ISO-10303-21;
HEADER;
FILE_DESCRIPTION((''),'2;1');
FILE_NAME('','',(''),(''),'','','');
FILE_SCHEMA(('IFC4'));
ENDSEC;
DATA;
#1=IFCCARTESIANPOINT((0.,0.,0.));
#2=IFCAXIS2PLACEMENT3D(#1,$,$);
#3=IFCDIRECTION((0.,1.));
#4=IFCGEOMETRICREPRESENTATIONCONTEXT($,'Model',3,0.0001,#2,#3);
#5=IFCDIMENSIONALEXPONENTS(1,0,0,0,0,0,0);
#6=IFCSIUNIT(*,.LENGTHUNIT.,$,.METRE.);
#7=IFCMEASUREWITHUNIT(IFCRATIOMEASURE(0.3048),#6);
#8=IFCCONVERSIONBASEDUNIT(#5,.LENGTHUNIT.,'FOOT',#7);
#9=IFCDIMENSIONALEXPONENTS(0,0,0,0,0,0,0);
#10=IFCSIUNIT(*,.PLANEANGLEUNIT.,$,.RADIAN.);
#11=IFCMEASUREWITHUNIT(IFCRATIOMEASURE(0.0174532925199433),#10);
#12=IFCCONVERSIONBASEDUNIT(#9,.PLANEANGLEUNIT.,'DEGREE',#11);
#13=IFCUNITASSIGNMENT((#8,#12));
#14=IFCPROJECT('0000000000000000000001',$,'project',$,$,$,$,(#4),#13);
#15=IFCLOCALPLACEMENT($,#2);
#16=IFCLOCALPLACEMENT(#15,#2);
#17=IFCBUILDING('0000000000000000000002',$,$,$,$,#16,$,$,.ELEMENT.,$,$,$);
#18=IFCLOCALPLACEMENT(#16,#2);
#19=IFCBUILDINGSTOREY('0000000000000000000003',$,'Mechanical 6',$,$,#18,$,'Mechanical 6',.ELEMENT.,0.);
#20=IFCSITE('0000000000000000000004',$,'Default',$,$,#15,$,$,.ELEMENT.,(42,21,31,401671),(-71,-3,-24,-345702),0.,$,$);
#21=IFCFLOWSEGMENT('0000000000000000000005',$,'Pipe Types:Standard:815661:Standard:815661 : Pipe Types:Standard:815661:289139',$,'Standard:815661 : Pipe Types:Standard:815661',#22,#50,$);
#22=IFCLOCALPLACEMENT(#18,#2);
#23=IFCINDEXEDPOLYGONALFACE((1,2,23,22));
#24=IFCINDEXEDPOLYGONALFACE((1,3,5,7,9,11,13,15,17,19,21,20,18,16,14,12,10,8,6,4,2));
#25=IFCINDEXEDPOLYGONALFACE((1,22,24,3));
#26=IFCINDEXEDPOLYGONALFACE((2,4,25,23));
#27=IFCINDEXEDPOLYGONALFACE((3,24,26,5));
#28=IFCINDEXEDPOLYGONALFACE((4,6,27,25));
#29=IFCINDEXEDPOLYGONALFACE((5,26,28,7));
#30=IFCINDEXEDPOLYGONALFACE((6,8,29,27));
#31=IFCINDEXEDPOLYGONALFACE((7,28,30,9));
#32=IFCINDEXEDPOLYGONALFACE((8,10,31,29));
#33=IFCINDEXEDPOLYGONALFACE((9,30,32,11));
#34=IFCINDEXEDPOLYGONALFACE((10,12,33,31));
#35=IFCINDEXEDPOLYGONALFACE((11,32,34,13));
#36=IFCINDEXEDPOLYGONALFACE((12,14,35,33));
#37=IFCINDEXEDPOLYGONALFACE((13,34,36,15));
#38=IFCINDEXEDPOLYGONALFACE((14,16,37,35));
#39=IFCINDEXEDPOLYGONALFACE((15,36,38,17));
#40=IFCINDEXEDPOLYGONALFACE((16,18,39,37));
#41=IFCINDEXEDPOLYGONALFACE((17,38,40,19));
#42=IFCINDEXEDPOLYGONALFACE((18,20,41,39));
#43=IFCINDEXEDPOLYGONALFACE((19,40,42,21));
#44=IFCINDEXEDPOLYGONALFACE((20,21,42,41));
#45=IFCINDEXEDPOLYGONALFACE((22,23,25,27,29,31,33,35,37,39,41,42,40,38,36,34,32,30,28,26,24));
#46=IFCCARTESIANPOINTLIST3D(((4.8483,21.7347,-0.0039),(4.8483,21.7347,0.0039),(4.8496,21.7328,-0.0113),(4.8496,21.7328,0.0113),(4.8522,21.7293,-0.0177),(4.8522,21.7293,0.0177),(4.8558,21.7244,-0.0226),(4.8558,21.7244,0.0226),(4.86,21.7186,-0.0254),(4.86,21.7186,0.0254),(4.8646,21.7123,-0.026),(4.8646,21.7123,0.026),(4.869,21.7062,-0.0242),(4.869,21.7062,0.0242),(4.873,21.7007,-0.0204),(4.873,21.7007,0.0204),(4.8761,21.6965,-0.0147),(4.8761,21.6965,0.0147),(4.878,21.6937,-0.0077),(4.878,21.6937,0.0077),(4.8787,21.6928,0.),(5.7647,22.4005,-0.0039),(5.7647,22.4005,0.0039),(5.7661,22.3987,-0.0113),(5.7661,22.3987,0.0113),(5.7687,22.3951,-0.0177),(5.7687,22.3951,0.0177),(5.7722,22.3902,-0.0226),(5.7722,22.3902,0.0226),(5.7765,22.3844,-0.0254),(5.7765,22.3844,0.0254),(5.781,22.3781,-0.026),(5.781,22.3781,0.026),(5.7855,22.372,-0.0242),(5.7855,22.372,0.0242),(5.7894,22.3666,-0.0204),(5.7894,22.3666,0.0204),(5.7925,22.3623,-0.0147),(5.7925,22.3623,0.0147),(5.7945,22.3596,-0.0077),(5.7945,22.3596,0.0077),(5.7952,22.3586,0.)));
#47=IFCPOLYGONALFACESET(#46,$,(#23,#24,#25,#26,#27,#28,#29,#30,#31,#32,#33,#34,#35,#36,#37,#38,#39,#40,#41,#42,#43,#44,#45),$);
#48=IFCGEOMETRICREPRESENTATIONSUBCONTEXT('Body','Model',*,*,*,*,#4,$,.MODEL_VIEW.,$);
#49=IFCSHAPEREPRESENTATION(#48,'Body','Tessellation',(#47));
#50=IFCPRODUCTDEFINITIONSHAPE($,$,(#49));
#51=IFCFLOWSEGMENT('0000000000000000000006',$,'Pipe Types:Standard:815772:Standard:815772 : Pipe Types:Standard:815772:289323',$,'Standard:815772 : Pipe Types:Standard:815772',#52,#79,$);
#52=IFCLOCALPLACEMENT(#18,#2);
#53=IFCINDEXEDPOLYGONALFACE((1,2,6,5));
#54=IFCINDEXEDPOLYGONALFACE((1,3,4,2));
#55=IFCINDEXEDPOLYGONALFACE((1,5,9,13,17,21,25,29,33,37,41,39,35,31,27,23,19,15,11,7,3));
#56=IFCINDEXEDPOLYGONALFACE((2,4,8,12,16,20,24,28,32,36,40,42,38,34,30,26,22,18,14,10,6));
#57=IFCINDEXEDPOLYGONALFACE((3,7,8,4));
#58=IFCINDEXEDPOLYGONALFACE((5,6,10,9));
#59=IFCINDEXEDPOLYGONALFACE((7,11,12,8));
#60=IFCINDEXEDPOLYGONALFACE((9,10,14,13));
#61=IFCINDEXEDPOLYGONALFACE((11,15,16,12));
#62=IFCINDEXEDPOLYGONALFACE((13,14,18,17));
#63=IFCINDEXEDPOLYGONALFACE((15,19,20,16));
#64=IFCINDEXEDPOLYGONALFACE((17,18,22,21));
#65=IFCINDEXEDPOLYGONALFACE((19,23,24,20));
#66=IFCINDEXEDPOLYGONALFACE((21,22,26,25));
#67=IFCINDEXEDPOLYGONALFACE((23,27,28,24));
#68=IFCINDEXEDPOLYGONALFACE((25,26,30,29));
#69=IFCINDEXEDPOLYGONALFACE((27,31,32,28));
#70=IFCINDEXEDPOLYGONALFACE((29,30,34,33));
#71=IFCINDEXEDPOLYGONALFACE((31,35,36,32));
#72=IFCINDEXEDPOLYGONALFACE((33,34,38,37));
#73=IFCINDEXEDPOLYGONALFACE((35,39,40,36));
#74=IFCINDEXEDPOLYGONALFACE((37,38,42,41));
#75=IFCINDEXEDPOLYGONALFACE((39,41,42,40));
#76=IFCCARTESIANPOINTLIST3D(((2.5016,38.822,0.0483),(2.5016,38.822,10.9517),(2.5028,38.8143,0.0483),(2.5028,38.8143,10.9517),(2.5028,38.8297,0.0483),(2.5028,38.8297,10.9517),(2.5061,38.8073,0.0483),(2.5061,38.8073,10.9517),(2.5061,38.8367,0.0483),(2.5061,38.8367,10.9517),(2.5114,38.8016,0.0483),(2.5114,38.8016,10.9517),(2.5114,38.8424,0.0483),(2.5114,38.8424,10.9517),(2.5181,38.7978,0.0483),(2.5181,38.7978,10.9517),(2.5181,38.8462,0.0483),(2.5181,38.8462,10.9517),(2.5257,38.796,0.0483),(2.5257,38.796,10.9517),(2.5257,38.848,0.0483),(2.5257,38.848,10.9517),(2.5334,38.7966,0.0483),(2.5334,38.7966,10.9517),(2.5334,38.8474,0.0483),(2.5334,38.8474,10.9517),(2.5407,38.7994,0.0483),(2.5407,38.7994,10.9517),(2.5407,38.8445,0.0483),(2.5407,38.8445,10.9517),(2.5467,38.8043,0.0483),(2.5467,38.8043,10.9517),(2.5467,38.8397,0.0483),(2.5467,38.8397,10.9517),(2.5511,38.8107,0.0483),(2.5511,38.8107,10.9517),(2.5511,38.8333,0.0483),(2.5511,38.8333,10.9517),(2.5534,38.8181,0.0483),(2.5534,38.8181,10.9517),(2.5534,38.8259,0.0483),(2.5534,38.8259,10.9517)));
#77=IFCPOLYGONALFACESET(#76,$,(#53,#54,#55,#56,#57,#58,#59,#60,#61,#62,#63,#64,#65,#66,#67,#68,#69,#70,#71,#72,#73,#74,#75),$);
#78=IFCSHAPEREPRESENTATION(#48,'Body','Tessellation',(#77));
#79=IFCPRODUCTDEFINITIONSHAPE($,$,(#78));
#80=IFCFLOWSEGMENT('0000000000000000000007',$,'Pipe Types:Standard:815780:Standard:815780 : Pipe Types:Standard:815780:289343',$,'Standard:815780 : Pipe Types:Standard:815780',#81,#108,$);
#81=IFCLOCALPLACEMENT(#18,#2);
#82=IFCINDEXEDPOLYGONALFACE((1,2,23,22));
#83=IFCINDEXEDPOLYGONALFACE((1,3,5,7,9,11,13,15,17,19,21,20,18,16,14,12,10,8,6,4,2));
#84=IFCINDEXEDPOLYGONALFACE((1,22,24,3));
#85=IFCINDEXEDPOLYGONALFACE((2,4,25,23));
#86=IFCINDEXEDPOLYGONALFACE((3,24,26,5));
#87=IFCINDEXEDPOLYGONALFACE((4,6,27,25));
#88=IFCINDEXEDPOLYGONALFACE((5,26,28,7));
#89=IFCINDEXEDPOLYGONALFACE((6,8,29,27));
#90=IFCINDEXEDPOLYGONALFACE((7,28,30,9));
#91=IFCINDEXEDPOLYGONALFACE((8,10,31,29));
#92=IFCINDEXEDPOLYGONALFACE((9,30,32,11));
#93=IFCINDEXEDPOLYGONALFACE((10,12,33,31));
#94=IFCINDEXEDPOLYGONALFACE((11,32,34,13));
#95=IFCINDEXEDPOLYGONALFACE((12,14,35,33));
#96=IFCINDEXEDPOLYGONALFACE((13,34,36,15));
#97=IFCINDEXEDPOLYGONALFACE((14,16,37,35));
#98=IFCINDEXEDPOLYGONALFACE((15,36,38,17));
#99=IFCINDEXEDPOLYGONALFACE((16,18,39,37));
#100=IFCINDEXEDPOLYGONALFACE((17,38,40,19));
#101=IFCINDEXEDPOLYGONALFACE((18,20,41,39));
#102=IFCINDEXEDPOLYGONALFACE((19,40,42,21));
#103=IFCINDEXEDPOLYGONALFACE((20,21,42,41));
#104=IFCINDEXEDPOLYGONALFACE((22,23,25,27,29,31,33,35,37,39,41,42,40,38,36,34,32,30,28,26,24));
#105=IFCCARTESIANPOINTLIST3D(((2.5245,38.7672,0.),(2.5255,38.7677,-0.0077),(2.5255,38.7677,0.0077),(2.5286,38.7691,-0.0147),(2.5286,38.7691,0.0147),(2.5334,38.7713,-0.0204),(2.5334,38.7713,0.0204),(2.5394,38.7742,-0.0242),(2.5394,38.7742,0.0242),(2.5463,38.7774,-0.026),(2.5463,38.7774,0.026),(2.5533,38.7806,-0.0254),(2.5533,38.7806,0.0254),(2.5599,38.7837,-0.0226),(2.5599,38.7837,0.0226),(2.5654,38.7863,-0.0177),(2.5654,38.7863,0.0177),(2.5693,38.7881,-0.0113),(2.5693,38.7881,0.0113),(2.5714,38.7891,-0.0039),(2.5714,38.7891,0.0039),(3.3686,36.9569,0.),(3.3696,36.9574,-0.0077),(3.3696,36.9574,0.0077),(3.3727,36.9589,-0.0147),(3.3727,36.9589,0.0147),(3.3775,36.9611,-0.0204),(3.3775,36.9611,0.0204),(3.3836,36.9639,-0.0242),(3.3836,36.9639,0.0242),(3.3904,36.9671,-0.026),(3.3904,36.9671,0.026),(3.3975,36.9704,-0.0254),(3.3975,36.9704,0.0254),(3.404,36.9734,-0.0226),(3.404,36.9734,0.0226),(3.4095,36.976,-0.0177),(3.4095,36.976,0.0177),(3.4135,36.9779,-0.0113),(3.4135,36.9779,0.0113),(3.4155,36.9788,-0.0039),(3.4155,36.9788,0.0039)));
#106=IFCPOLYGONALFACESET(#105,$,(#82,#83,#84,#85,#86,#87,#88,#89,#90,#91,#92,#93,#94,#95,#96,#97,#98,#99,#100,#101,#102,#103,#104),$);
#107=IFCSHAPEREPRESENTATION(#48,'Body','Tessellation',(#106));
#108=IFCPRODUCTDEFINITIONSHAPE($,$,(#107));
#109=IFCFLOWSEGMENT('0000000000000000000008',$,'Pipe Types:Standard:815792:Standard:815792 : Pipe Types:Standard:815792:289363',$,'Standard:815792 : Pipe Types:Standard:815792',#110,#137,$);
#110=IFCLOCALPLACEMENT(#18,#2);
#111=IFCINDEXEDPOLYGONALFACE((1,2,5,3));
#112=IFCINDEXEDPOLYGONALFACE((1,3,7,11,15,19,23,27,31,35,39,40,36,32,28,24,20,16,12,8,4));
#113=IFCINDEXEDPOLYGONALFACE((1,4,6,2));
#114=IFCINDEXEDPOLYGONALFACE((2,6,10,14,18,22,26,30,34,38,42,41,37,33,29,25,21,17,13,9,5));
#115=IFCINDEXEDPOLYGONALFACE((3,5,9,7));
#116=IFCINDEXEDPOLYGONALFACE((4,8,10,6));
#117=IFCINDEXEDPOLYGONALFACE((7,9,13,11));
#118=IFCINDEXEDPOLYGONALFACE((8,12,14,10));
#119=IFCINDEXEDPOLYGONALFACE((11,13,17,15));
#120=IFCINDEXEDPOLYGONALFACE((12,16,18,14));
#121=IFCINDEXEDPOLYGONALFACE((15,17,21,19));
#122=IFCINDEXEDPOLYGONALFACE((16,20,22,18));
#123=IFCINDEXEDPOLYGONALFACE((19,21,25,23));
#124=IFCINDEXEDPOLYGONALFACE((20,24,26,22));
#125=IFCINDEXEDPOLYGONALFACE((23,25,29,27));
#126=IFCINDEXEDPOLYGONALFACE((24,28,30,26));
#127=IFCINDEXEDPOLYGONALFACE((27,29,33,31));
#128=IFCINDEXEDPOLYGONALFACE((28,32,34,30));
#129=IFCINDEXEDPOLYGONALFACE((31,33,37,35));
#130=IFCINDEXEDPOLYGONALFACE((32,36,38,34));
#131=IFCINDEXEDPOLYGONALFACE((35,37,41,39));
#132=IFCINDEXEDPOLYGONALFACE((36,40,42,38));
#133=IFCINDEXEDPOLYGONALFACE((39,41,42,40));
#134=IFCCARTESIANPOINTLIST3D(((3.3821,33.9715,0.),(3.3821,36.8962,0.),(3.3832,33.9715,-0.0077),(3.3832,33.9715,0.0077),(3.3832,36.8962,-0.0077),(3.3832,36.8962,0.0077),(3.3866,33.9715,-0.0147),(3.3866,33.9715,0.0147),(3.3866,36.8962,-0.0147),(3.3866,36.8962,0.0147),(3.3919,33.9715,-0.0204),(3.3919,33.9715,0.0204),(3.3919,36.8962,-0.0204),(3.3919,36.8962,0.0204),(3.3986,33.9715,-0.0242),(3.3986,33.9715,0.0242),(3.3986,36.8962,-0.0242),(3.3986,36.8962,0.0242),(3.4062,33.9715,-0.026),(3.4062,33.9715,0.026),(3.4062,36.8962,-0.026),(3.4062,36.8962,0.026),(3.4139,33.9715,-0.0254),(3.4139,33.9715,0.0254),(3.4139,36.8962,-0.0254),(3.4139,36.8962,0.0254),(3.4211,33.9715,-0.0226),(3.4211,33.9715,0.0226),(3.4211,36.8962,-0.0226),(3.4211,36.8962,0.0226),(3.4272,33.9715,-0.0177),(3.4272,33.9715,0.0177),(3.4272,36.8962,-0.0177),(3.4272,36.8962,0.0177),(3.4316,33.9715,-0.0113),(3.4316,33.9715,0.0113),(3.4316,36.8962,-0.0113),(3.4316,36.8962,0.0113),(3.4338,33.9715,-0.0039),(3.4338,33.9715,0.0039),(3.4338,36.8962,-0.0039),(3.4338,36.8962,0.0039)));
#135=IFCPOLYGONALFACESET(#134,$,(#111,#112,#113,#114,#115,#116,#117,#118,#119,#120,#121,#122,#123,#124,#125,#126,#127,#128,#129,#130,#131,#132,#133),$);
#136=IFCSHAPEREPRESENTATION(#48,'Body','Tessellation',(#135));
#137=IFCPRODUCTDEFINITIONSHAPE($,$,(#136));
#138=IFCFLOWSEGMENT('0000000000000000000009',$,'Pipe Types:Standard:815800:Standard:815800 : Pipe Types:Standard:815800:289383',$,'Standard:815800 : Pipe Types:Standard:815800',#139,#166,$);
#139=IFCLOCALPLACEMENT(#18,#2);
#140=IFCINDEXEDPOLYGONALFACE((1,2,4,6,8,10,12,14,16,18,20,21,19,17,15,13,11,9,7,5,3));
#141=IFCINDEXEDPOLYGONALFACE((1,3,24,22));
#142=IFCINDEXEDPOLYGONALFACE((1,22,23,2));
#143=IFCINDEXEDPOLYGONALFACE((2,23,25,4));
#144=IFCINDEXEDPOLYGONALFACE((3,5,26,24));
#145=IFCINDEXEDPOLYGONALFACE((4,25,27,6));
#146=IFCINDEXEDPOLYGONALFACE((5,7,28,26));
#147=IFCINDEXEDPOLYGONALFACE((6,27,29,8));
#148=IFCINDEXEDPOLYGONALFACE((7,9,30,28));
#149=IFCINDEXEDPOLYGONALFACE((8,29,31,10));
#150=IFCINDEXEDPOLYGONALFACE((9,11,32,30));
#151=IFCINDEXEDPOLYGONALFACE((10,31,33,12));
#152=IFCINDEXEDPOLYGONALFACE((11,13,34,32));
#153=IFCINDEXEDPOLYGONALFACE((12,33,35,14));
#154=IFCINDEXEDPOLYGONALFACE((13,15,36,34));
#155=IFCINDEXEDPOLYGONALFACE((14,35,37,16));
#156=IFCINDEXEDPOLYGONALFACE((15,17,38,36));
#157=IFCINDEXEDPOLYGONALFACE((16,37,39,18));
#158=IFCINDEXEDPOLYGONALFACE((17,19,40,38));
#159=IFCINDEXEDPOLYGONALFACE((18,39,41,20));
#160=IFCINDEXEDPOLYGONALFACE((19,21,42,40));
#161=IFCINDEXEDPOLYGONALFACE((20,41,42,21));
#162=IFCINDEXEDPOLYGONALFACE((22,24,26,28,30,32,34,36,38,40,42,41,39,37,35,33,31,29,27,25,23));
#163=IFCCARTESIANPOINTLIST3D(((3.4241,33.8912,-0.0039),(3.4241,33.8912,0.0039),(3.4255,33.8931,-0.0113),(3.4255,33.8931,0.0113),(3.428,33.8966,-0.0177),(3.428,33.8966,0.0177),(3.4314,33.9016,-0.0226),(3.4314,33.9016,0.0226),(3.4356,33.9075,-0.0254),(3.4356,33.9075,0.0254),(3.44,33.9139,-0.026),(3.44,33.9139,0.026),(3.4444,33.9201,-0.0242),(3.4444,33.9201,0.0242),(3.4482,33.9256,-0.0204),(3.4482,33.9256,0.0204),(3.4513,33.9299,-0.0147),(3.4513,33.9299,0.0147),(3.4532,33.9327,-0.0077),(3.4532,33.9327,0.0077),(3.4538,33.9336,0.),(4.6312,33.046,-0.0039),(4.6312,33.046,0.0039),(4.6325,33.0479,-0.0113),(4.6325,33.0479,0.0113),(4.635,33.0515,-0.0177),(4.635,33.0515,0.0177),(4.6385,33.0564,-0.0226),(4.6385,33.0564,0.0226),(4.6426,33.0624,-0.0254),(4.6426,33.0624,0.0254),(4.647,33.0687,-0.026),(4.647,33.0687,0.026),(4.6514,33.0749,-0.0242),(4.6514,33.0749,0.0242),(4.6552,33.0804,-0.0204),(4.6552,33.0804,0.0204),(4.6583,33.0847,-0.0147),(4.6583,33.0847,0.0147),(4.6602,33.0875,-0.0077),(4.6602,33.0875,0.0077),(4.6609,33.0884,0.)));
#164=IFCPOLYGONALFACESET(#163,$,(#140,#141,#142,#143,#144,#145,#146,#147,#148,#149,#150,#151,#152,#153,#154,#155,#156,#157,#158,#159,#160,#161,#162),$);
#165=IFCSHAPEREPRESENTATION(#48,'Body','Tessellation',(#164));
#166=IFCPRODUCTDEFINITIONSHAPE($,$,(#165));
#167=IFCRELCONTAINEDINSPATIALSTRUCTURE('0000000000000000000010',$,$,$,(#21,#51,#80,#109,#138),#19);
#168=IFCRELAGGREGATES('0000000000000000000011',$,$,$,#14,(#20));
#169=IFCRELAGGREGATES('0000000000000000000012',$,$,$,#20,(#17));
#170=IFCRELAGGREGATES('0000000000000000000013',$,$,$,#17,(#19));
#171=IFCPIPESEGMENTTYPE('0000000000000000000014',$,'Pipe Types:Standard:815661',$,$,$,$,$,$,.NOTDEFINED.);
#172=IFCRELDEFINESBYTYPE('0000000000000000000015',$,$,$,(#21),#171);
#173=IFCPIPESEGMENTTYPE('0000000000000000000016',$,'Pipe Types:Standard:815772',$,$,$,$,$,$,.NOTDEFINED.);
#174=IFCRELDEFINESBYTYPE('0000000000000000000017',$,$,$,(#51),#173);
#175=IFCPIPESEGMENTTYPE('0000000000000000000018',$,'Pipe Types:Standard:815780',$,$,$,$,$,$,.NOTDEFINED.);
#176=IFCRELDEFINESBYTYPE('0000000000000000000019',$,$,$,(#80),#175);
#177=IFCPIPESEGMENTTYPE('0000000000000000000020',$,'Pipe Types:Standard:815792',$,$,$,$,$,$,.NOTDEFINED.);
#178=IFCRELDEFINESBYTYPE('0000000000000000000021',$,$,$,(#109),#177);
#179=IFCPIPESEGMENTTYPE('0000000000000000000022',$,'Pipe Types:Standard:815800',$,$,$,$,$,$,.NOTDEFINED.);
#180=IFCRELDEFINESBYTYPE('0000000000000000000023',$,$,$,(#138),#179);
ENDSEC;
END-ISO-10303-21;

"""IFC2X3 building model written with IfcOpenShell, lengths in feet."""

from ifc_helpers import new_model, entity, si_unit, converted_unit, direction, frame, frame_2d, origin, origin_2d_with_axis, place, context, subcontext, project, spatial, circle, extrude, source, transform, mapped, type_object, type_shapes, element, save


model = new_model("IFC2X3")

# Units and contexts
model_context = context("Model", 3, precision=0.0001, world=origin(), true_north=direction((0.0, 1.0)))
body_context = subcontext(model_context, "Body", "Model", "MODEL_VIEW")
ifc_project = project(units=[converted_unit("LENGTHUNIT", "FOOT", entity("IfcRatioMeasure", 0.3048), si_unit("LENGTHUNIT", "METRE"), dimensions=[1, 0, 0, 0, 0, 0, 0]), converted_unit("PLANEANGLEUNIT", "DEGREE", entity("IfcRatioMeasure", 0.0174532925199433), si_unit("PLANEANGLEUNIT", "RADIAN"), dimensions=[0, 0, 0, 0, 0, 0, 0])], contexts=[model_context])

# Site, building, storey
site_placement = place(None, origin())
site = spatial("IfcSite", under=ifc_project, at=site_placement, Name="Default", CompositionType="ELEMENT", RefLatitude=(42, 21, 31, 401671), RefLongitude=(-71, -3, -24, -345702), RefElevation=0.0)
building_placement = place(site_placement, origin())
building = spatial("IfcBuilding", under=site, at=building_placement, CompositionType="ELEMENT")
storey_placement = place(building_placement, origin())
storey = spatial("IfcBuildingStorey", under=building, at=storey_placement, Name="Mechanical 6", LongName="Mechanical 6", CompositionType="ELEMENT", Elevation=0.0)

# Flow segments
pipe_segment_type_1 = type_object("IfcPipeSegmentType", Name="Pipe Types:Standard:815661", PredefinedType="NOTDEFINED")
shared_shape_1 = source(origin(), body_context, "Body", "SweptSolid", [
    extrude(circle(Radius=0.026, at=frame_2d((0.0, 0.0), x_axis=(1.0, 0.0))), frame((4.8634, 21.7139, 0.0), z_axis=(0.809017, 0.587785, 0.0), x_axis=(0.587785, -0.809017, 0.0)), (0.0, 0.0, 1.0), 1.1328),
])
type_shapes(pipe_segment_type_1, [shared_shape_1])
flow_segment_1_placement = place(building_placement, origin())
element("IfcFlowSegment", 1, at=flow_segment_1_placement, inside=storey, type_object=pipe_segment_type_1, Name="Pipe Types:Standard:815661:Standard:815661 : Pipe Types:Standard:815661:289139", ObjectType="Standard:815661 : Pipe Types:Standard:815661", context=body_context, shape_type="MappedRepresentation", body=[
    mapped(shared_shape_1, transform((0.0, 0.0, 0.0), scale=1.0)),
])
pipe_segment_type_2 = type_object("IfcPipeSegmentType", Name="Pipe Types:Standard:815772", PredefinedType="NOTDEFINED")
shared_shape_2 = source(origin(), body_context, "Body", "SweptSolid", [
    extrude(circle(Radius=0.026, at=origin_2d_with_axis()), frame((2.5276, 38.822, 0.0483), z_axis=(0.0, 0.0, 1.0), x_axis=(-1.0, 0.0, 0.0)), (0.0, 0.0, 1.0), 10.9033),
])
type_shapes(pipe_segment_type_2, [shared_shape_2])
flow_segment_2_placement = place(building_placement, origin())
element("IfcFlowSegment", 2, at=flow_segment_2_placement, inside=storey, type_object=pipe_segment_type_2, Name="Pipe Types:Standard:815772:Standard:815772 : Pipe Types:Standard:815772:289323", ObjectType="Standard:815772 : Pipe Types:Standard:815772", context=body_context, shape_type="MappedRepresentation", body=[
    mapped(shared_shape_2, transform((0.0, 0.0, 0.0), scale=1.0)),
])
pipe_segment_type_3 = type_object("IfcPipeSegmentType", Name="Pipe Types:Standard:815780", PredefinedType="NOTDEFINED")
shared_shape_3 = source(origin(), body_context, "Body", "SweptSolid", [
    extrude(circle(Radius=0.026, at=frame_2d((0.0, 0.0), x_axis=(1.0, 0.0))), frame((2.5481, 38.7782, 0.0), z_axis=(0.422618, -0.906308, 0.0), x_axis=(-0.906308, -0.422618, 0.0)), (0.0, 0.0, 1.0), 1.9974),
])
type_shapes(pipe_segment_type_3, [shared_shape_3])
flow_segment_3_placement = place(building_placement, origin())
element("IfcFlowSegment", 3, at=flow_segment_3_placement, inside=storey, type_object=pipe_segment_type_3, Name="Pipe Types:Standard:815780:Standard:815780 : Pipe Types:Standard:815780:289343", ObjectType="Standard:815780 : Pipe Types:Standard:815780", context=body_context, shape_type="MappedRepresentation", body=[
    mapped(shared_shape_3, transform((0.0, 0.0, 0.0), scale=1.0)),
])
pipe_segment_type_4 = type_object("IfcPipeSegmentType", Name="Pipe Types:Standard:815792", PredefinedType="NOTDEFINED")
shared_shape_4 = source(origin(), body_context, "Body", "SweptSolid", [
    extrude(circle(Radius=0.026, at=frame_2d((0.0, 0.0), x_axis=(1.0, 0.0))), frame((3.4081, 33.9715, 0.0), z_axis=(0.0, 1.0, 0.0), x_axis=(-1.0, 0.0, 0.0)), (0.0, 0.0, 1.0), 2.9248),
])
type_shapes(pipe_segment_type_4, [shared_shape_4])
flow_segment_4_placement = place(building_placement, origin())
element("IfcFlowSegment", 4, at=flow_segment_4_placement, inside=storey, type_object=pipe_segment_type_4, Name="Pipe Types:Standard:815792:Standard:815792 : Pipe Types:Standard:815792:289363", ObjectType="Standard:815792 : Pipe Types:Standard:815792", context=body_context, shape_type="MappedRepresentation", body=[
    mapped(shared_shape_4, transform((0.0, 0.0, 0.0), scale=1.0)),
])
pipe_segment_type_5 = type_object("IfcPipeSegmentType", Name="Pipe Types:Standard:815800", PredefinedType="NOTDEFINED")
shared_shape_5 = source(origin(), body_context, "Body", "SweptSolid", [
    extrude(circle(Radius=0.026, at=frame_2d((0.0, 0.0), x_axis=(1.0, 0.0))), frame((3.4389, 33.9123, 0.0), z_axis=(0.819152, -0.573576, 0.0), x_axis=(0.573576, 0.819152, 0.0)), (0.0, 0.0, 1.0), 1.4735),
])
type_shapes(pipe_segment_type_5, [shared_shape_5])
flow_segment_5_placement = place(building_placement, origin())
element("IfcFlowSegment", 5, at=flow_segment_5_placement, inside=storey, type_object=pipe_segment_type_5, Name="Pipe Types:Standard:815800:Standard:815800 : Pipe Types:Standard:815800:289383", ObjectType="Standard:815800 : Pipe Types:Standard:815800", context=body_context, shape_type="MappedRepresentation", body=[
    mapped(shared_shape_5, transform((0.0, 0.0, 0.0), scale=1.0)),
])

save(model, "model.ifc")
